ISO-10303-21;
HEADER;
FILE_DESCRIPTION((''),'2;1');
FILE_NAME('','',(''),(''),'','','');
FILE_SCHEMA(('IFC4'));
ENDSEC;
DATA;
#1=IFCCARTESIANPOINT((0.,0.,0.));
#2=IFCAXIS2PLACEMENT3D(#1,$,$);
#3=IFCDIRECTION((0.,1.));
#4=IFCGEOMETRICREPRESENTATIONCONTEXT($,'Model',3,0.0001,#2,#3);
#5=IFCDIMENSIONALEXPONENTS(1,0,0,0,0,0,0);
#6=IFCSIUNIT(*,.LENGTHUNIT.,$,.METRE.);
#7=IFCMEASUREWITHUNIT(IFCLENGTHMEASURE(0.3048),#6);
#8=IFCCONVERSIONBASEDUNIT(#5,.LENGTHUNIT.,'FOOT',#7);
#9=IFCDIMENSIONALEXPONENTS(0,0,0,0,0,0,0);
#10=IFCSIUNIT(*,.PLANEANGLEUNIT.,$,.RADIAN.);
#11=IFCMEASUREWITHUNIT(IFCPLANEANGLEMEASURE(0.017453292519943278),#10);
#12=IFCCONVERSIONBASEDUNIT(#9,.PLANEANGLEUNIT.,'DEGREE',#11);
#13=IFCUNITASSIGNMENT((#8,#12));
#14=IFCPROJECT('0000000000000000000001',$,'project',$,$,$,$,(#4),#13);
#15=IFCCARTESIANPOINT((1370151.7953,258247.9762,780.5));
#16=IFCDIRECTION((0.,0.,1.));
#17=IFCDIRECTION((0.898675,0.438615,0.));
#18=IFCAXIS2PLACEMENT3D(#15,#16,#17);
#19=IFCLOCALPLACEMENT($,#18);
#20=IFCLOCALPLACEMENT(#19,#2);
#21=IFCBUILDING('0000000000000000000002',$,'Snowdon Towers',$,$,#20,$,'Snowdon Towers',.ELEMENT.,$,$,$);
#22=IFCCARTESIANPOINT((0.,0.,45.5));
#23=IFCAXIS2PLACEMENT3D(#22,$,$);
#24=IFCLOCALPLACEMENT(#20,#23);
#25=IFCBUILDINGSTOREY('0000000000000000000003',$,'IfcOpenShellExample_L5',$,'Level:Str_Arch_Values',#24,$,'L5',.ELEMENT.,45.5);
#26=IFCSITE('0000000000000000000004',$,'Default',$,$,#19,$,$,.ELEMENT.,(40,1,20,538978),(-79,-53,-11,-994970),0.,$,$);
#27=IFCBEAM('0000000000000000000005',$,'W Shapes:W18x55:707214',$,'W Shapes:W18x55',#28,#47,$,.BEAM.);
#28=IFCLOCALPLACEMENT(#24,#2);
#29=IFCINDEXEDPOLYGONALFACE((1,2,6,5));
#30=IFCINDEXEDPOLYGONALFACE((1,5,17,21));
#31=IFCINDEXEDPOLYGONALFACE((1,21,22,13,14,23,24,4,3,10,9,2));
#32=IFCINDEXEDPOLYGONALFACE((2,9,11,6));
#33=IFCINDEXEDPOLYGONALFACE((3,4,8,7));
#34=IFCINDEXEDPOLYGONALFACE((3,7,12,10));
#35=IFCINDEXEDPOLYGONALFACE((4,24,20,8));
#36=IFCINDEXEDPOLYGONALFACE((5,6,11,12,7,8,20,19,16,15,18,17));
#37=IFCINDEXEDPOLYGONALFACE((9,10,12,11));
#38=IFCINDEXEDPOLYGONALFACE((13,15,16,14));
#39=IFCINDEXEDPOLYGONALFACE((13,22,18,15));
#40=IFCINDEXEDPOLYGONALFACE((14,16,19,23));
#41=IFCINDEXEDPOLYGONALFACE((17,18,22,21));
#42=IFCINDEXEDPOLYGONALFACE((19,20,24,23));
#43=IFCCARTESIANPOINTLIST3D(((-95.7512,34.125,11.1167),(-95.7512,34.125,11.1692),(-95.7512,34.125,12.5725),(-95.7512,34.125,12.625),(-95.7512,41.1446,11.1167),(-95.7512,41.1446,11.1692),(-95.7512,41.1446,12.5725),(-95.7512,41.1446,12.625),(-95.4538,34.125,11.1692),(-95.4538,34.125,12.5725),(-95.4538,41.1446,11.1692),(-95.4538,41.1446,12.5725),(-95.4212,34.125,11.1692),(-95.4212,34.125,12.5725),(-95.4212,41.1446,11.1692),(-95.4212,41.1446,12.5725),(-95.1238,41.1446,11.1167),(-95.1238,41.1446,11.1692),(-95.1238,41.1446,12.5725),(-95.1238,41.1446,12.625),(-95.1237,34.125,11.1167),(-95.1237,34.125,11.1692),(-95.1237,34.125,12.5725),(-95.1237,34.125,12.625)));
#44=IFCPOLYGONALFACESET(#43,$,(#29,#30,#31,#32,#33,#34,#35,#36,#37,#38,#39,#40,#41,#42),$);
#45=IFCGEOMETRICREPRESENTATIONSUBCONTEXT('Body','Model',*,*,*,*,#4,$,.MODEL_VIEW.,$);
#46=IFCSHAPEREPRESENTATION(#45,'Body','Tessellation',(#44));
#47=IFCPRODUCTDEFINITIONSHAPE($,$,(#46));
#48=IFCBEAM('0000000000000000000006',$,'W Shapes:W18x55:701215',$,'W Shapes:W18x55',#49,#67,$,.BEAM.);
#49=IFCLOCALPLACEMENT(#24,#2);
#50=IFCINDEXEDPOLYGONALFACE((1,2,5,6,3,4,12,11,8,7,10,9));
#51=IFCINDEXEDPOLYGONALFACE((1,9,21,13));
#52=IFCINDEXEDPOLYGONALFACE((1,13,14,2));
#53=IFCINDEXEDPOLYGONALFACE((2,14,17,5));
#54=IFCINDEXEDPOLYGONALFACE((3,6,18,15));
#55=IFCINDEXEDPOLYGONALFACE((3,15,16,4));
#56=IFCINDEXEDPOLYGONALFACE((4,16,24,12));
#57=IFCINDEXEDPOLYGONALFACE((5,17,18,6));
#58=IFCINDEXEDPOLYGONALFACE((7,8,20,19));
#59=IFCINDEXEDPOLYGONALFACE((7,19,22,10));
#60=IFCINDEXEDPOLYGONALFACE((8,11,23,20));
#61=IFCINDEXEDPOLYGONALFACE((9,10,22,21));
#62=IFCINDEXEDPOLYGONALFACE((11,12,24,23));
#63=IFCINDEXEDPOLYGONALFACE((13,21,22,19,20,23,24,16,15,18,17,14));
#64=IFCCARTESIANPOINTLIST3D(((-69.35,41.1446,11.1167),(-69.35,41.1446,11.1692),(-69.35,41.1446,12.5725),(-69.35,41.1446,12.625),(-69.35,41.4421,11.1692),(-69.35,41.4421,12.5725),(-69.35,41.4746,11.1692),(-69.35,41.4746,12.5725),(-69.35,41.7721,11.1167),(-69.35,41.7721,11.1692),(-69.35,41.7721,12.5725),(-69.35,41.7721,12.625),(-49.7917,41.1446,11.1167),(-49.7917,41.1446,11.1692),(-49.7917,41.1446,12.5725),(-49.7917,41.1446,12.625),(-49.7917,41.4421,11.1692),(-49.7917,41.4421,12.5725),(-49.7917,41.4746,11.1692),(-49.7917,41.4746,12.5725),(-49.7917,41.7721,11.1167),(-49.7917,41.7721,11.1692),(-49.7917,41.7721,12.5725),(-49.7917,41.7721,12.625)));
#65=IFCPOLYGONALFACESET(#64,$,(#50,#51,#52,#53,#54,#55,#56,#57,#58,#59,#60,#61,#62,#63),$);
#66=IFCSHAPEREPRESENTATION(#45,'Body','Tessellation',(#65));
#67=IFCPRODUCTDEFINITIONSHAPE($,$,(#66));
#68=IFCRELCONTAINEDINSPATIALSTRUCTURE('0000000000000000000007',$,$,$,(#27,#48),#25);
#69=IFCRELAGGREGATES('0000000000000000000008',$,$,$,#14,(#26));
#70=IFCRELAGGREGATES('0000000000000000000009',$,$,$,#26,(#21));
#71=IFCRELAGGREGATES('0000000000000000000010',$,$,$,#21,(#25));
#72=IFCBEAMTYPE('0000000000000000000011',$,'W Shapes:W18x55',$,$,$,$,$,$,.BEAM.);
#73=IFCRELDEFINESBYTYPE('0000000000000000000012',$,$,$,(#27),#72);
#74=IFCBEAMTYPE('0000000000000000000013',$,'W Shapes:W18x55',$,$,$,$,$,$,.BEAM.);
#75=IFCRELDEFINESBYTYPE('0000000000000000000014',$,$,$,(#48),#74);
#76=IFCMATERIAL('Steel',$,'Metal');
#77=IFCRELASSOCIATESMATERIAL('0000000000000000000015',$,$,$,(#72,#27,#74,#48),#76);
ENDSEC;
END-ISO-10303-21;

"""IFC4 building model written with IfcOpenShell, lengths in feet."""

from ifc_helpers import new_model, entity, si_unit, converted_unit, direction, frame, origin, place, context, subcontext, project, spatial, indexed_curve, outline, extrude, source, transform, mapped, material, type_object, type_shapes, element, save


model = new_model("IFC4")

# Units and contexts
model_context = context("Model", 3, precision=0.0001, world=origin(), true_north=direction((0.0, 1.0)))
body_context = subcontext(model_context, "Body", "Model", "MODEL_VIEW")
ifc_project = project(units=[converted_unit("LENGTHUNIT", "FOOT", entity("IfcLengthMeasure", 0.3048), si_unit("LENGTHUNIT", "METRE"), dimensions=[1, 0, 0, 0, 0, 0, 0]), converted_unit("PLANEANGLEUNIT", "DEGREE", entity("IfcPlaneAngleMeasure", 0.017453292519943278), si_unit("PLANEANGLEUNIT", "RADIAN"), dimensions=[0, 0, 0, 0, 0, 0, 0])], contexts=[model_context])

# Site, building, storey
site_placement = place(None, frame((1370151.7953, 258247.9762, 780.5), z_axis=(0.0, 0.0, 1.0), x_axis=(0.898675, 0.438615, 0.0)))
site = spatial("IfcSite", under=ifc_project, at=site_placement, Name="Default", CompositionType="ELEMENT", RefLatitude=(40, 1, 20, 538978), RefLongitude=(-79, -53, -11, -994970), RefElevation=0.0)
building_placement = place(site_placement, origin())
building = spatial("IfcBuilding", under=site, at=building_placement, Name="Snowdon Towers", LongName="Snowdon Towers", CompositionType="ELEMENT")
storey_placement = place(building_placement, frame((0.0, 0.0, 45.5)))
storey = spatial("IfcBuildingStorey", under=building, at=storey_placement, Name="IfcOpenShellExample_L5", ObjectType="Level:Str_Arch_Values", LongName="L5", CompositionType="ELEMENT", Elevation=45.5)

# Beams
ifc_material = material(Name="Steel", Category="Metal")
beam_type_1 = type_object("IfcBeamType", Name="W Shapes:W18x55", PredefinedType="BEAM", material=ifc_material)
shared_shape_1 = source(origin(), body_context, "Body", "SweptSolid", [
    extrude(outline(indexed_curve([(-0.3138, -0.7017), (-0.3138, -0.7542), (0.3138, -0.7542), (0.3138, -0.7017), (0.0162, -0.7017), (0.0162, 0.7017), (0.3138, 0.7017), (0.3138, 0.7542), (-0.3137, 0.7542), (-0.3137, 0.7017), (-0.0163, 0.7017), (-0.0163, -0.7017), (-0.3138, -0.7017)], self_intersect=False)), frame((-3.3529, 0.0, 0.0), z_axis=(-1.0, 0.0, 0.0), x_axis=(0.0, -1.0, 0.0)), (0.0, 0.0, -1.0), 7.0196),
])
type_shapes(beam_type_1, [shared_shape_1])
beam_1_placement = place(storey_placement, frame((-95.4375, 37.7917, 11.8708), z_axis=(0.0, 0.0, 1.0), x_axis=(0.0, -1.0, 0.0)))
element("IfcBeam", 1, at=beam_1_placement, inside=storey, type_object=beam_type_1, material=ifc_material, Name="W Shapes:W18x55:707214", ObjectType="W Shapes:W18x55", PredefinedType="BEAM", context=body_context, shape_type="MappedRepresentation", body=[
    mapped(shared_shape_1, transform((0.0, 0.0, 0.0), scale=1.0)),
])
beam_type_2 = type_object("IfcBeamType", Name="W Shapes:W18x55", PredefinedType="BEAM", material=ifc_material)
shared_shape_2 = source(origin(), body_context, "Body", "SweptSolid", [
    extrude(outline(indexed_curve([(-0.3138, -0.7017), (-0.3138, -0.7542), (0.3138, -0.7542), (0.3138, -0.7017), (0.0162, -0.7017), (0.0162, 0.7017), (0.3138, 0.7017), (0.3138, 0.7542), (-0.3137, 0.7542), (-0.3137, 0.7017), (-0.0163, 0.7017), (-0.0163, -0.7017), (-0.3138, -0.7017)], self_intersect=False)), frame((-9.725, 0.0, 0.0), z_axis=(-1.0, 0.0, 0.0), x_axis=(0.0, -1.0, 0.0)), (0.0, 0.0, -1.0), 19.5583),
])
type_shapes(beam_type_2, [shared_shape_2])
beam_2_placement = place(storey_placement, frame((-59.625, 41.4583, 11.8708)))
element("IfcBeam", 2, at=beam_2_placement, inside=storey, type_object=beam_type_2, material=ifc_material, Name="W Shapes:W18x55:701215", ObjectType="W Shapes:W18x55", PredefinedType="BEAM", context=body_context, shape_type="MappedRepresentation", body=[
    mapped(shared_shape_2, transform((0.0, 0.0, 0.0), scale=1.0)),
])

save(model, "model.ifc")
